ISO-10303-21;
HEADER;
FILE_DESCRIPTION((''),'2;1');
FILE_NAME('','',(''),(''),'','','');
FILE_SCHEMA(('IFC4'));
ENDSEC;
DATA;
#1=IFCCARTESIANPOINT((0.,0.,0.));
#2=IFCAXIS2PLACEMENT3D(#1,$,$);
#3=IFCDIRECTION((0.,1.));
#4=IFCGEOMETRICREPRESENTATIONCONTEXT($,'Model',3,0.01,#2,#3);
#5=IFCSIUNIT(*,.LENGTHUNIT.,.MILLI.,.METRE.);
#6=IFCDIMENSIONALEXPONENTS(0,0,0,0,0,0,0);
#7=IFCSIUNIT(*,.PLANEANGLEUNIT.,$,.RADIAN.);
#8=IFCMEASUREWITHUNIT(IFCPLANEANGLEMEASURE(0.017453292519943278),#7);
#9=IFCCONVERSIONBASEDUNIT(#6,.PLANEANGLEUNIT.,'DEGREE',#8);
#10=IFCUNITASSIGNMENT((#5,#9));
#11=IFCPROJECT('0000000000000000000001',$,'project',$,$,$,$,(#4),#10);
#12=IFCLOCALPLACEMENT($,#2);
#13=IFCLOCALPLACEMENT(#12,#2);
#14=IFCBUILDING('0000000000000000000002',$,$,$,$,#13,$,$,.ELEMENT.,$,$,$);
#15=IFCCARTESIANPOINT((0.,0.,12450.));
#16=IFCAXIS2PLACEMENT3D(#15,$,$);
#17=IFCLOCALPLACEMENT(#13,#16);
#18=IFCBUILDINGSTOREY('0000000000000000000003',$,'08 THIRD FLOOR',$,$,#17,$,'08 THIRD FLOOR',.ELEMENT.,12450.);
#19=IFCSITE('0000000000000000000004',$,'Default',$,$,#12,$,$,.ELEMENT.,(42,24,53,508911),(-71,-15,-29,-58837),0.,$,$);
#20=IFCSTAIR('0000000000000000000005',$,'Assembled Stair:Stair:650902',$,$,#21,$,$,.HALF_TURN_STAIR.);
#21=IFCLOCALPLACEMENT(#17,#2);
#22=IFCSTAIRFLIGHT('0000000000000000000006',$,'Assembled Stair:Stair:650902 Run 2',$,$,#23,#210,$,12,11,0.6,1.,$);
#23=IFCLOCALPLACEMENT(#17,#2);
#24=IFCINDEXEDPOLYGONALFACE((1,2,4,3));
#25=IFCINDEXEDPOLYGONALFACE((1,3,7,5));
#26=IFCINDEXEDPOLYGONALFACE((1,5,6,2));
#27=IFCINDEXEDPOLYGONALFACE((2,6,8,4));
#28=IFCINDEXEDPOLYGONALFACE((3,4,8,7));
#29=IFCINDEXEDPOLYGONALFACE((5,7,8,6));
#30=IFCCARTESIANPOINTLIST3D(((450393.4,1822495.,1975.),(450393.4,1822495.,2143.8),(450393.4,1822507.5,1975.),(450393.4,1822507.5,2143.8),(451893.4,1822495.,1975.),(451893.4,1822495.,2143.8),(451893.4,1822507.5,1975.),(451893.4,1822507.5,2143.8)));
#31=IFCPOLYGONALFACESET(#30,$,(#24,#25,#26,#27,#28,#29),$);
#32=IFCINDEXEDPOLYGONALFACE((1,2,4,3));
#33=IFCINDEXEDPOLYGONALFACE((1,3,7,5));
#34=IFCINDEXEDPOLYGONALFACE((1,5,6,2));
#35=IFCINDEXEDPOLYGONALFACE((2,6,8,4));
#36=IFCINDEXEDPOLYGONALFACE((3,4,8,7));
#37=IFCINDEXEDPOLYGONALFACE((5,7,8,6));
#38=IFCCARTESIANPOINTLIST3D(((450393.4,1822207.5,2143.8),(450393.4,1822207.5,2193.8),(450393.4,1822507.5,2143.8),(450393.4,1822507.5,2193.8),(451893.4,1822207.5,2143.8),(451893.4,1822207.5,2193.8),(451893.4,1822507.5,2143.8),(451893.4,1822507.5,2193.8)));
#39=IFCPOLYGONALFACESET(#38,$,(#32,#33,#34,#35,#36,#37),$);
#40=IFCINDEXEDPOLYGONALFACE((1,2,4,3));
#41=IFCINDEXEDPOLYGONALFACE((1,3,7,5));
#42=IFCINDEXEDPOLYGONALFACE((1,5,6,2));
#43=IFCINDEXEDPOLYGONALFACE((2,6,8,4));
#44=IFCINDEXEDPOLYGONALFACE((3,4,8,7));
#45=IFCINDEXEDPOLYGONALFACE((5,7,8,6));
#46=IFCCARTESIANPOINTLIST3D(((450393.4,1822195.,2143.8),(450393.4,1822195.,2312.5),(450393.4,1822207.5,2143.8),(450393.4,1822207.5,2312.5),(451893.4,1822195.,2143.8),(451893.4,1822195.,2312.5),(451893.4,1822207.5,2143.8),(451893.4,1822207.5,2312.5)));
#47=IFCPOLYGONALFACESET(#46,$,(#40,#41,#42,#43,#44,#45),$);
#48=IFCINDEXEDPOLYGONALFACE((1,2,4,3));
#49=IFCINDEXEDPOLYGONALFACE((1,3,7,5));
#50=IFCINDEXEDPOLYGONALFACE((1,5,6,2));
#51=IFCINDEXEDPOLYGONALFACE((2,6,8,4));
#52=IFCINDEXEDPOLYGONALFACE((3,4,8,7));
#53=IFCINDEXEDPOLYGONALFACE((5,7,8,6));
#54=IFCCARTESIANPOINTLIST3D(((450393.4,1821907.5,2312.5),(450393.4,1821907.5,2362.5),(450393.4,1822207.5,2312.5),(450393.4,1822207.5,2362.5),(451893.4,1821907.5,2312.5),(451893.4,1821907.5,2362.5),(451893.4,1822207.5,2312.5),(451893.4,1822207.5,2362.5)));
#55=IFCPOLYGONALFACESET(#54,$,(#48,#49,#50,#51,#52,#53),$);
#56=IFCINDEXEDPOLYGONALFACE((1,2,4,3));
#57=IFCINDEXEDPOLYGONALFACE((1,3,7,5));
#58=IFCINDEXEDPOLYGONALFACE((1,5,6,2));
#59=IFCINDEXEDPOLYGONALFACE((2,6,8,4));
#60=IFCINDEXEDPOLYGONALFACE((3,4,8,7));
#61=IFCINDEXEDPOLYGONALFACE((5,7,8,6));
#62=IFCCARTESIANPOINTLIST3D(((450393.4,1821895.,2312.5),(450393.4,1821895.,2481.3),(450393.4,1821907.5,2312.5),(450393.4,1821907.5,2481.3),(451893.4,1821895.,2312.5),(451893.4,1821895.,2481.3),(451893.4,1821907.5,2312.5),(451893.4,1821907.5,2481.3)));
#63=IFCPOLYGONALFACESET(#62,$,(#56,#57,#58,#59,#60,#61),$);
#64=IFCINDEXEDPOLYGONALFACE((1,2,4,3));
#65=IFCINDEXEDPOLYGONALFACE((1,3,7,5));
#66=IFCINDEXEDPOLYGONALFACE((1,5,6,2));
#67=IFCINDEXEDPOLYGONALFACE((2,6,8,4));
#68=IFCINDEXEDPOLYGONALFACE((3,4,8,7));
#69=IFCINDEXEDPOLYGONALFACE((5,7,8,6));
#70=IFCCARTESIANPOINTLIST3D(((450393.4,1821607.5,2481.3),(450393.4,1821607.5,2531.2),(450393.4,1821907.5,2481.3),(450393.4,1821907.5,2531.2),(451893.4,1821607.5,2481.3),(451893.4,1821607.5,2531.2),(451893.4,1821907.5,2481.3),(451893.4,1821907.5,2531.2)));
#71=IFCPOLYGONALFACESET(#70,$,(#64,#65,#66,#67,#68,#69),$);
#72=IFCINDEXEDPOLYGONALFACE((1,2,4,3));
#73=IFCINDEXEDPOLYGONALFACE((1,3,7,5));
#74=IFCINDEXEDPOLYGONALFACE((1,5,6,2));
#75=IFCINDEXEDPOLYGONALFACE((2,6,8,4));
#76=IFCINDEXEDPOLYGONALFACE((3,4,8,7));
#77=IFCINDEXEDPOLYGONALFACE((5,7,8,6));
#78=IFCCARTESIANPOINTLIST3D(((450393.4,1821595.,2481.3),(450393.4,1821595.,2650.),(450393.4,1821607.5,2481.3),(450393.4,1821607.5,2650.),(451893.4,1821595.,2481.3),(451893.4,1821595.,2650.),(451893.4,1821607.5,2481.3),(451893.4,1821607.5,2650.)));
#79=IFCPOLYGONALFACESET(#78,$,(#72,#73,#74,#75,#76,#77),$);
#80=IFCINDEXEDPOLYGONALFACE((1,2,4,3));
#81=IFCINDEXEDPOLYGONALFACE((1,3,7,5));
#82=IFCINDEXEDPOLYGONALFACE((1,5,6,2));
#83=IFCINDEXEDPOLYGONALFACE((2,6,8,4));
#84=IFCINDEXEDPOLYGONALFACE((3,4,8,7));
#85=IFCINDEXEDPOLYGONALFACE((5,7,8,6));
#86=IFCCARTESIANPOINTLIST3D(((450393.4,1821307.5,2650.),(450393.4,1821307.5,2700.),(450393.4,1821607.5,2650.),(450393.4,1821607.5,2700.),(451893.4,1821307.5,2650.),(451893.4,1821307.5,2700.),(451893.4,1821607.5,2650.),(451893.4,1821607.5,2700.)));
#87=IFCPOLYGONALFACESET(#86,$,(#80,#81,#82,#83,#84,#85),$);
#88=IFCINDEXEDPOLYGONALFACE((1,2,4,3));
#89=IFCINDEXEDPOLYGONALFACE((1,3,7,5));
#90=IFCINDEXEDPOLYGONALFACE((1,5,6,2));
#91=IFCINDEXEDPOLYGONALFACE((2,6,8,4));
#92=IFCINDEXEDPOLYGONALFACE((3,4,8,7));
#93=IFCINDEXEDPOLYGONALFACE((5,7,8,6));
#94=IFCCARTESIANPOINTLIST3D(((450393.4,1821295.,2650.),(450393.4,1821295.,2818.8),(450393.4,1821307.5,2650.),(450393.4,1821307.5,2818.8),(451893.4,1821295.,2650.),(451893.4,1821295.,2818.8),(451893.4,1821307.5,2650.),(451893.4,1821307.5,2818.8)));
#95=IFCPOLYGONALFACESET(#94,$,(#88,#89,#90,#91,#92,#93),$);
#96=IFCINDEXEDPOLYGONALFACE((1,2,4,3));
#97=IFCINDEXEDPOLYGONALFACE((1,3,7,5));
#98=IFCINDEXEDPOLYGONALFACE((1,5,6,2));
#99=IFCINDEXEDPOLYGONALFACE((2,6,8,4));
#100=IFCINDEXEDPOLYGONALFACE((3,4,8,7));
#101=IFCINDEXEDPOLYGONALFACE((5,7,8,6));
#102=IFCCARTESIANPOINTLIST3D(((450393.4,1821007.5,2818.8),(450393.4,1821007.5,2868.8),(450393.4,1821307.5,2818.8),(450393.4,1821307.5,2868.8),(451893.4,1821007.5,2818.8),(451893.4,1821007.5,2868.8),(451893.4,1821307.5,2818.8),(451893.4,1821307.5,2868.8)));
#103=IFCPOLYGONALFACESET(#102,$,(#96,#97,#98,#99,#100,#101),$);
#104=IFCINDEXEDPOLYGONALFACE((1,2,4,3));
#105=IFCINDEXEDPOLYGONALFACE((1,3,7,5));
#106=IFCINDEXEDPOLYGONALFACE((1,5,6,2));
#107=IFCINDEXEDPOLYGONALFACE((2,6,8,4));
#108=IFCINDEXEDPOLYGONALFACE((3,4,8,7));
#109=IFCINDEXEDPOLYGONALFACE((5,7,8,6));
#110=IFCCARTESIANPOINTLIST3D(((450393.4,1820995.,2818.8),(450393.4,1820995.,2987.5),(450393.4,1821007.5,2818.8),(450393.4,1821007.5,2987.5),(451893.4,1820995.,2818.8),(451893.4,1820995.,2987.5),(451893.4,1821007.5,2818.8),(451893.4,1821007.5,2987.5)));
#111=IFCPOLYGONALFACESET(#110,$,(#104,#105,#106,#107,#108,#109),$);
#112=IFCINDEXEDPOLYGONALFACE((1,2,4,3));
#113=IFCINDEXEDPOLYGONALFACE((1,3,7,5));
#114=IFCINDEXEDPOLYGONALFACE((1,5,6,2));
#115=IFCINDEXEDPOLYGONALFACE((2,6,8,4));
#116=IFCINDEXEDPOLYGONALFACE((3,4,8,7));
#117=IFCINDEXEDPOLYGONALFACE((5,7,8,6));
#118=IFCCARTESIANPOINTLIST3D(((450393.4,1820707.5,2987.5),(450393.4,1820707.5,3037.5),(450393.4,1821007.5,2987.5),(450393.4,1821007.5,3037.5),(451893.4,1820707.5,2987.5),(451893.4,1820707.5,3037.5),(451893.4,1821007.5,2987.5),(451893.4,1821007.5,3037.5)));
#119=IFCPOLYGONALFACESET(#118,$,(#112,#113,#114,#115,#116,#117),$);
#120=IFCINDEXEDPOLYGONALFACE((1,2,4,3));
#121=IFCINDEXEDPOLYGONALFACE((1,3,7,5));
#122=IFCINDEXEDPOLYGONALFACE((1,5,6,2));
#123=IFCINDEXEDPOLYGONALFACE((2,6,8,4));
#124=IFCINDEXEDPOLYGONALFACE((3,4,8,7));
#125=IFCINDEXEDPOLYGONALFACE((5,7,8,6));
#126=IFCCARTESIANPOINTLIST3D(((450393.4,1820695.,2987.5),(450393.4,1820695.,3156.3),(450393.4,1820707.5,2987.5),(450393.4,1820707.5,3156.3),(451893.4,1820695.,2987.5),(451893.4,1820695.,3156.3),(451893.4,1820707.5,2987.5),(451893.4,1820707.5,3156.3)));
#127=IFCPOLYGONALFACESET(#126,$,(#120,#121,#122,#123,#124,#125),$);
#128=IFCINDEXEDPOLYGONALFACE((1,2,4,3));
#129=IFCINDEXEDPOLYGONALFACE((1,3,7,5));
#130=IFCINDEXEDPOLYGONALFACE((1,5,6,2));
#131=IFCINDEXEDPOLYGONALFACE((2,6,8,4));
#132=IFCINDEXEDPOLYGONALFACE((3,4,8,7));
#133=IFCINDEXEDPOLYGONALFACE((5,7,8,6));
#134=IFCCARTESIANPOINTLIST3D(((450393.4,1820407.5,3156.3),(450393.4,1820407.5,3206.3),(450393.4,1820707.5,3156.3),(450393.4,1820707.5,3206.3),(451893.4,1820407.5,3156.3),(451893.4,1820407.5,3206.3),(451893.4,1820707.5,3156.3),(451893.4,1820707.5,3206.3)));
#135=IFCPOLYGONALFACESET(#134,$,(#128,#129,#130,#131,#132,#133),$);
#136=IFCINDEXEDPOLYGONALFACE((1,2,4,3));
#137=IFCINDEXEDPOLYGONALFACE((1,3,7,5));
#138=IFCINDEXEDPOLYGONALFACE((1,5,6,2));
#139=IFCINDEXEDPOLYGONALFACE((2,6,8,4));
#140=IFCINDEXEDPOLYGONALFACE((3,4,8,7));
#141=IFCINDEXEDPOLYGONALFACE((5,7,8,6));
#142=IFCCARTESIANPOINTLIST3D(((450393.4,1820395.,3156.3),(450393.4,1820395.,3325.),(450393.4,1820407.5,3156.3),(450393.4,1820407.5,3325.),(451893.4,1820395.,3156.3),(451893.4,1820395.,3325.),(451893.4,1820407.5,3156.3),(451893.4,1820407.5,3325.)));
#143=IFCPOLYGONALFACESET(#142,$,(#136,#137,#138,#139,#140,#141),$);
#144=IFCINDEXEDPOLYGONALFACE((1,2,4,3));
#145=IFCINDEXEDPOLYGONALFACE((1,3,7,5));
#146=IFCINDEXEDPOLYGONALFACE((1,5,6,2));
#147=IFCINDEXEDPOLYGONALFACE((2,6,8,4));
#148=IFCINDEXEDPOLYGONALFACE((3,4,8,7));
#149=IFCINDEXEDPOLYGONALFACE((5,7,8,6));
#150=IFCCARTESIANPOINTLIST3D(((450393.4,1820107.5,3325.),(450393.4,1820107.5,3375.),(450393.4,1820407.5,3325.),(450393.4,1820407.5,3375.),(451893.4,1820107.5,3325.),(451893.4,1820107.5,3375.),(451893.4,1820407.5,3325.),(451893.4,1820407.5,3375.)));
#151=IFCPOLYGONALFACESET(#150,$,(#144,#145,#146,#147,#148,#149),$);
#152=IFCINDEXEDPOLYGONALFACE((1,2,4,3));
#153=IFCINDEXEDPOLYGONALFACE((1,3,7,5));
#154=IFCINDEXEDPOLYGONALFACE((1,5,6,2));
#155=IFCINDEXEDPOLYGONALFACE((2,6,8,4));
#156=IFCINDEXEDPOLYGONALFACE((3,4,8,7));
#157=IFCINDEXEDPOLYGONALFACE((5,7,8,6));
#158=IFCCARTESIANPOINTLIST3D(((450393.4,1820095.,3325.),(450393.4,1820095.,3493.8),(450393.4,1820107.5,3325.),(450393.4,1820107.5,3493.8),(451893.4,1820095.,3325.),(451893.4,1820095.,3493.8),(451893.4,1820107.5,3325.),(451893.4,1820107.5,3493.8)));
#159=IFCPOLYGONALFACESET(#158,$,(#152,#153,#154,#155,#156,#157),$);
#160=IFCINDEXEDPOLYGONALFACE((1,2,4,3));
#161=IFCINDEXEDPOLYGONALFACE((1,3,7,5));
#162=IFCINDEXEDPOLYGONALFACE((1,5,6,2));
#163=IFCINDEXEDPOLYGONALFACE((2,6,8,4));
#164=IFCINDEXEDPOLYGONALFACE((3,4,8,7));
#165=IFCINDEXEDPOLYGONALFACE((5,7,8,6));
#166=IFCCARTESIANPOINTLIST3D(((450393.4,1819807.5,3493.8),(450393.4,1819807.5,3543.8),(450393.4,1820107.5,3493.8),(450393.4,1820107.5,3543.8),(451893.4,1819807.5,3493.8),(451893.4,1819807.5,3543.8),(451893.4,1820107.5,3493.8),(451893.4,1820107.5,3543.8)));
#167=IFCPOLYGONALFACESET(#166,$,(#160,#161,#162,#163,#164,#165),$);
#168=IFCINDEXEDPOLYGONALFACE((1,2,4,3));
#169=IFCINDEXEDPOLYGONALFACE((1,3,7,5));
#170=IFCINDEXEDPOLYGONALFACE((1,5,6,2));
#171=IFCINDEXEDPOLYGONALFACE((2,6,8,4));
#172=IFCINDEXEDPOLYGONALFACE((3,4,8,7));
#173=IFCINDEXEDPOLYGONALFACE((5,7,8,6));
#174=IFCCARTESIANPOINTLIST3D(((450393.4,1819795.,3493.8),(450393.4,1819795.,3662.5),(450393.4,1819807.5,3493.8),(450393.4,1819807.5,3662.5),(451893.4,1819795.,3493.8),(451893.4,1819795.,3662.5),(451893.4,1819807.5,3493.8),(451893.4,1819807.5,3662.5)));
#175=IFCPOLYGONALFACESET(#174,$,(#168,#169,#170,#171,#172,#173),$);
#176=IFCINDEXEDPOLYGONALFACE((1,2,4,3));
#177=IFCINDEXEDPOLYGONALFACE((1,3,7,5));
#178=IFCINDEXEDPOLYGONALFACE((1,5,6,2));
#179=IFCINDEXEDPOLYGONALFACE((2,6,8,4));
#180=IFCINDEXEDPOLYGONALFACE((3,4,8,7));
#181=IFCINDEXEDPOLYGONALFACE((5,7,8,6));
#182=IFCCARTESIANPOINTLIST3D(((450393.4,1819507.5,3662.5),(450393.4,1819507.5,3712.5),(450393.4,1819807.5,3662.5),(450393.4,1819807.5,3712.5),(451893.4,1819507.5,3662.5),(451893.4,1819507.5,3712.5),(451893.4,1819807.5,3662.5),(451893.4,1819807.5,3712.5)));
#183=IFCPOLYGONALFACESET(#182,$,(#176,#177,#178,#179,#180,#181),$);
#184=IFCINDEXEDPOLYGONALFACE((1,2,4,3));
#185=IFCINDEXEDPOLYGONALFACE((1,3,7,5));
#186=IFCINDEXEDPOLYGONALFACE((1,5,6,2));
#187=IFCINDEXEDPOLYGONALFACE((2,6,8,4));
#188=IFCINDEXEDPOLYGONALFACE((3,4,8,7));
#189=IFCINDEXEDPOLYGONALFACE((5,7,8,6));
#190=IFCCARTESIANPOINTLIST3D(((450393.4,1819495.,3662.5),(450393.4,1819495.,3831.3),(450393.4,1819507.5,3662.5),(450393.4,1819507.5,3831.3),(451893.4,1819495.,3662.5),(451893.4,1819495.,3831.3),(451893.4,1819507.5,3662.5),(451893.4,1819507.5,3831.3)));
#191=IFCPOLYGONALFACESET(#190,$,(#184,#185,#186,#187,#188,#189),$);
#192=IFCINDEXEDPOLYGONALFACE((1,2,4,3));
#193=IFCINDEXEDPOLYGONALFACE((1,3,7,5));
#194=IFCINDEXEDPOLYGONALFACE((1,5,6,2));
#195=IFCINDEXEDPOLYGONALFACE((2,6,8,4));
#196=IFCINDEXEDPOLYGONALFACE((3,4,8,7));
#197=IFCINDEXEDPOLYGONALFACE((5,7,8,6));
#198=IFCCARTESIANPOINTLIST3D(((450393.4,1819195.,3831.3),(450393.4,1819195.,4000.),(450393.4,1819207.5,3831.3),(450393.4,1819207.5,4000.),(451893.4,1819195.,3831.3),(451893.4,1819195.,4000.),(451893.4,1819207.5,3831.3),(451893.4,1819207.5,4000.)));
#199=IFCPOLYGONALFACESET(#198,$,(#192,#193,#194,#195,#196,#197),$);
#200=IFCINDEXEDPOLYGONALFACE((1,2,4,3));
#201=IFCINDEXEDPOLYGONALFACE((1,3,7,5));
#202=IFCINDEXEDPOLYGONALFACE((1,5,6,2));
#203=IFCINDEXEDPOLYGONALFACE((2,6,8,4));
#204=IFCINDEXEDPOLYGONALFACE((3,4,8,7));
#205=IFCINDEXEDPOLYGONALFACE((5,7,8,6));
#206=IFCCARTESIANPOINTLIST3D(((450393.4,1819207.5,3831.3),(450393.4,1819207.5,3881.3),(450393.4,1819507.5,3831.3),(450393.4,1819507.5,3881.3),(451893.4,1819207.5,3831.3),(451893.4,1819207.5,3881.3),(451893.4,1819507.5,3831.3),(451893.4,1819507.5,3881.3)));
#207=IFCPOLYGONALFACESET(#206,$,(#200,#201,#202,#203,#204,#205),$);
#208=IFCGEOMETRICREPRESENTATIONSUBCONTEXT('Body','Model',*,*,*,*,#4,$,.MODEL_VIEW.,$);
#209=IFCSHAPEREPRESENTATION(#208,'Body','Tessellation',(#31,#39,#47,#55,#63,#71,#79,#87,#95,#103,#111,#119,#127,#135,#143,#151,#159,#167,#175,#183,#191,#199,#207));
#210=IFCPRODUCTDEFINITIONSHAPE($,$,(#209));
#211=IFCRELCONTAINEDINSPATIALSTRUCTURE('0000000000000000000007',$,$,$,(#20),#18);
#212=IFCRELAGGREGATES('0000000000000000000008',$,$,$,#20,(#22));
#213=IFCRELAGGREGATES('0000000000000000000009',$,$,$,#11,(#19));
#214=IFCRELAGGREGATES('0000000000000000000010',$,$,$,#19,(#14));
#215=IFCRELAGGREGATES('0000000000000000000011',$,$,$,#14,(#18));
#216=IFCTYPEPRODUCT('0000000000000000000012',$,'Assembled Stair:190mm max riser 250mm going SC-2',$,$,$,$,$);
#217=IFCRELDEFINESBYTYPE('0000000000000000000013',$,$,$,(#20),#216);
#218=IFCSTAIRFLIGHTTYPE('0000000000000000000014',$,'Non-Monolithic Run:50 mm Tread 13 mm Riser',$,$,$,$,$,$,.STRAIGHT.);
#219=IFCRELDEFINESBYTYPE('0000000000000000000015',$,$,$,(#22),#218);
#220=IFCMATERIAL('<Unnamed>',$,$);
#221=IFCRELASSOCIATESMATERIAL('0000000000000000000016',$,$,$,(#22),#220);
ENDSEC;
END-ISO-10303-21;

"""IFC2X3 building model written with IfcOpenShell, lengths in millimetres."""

from ifc_helpers import new_model, entity, si_unit, converted_unit, direction, frame, frame_2d, origin, origin_2d_with_axis, place, context, subcontext, project, spatial, rectangle, extrude, material, type_object, element, aggregate, save


model = new_model("IFC2X3")

# Units and contexts
model_context = context("Model", 3, precision=0.01, world=origin(), true_north=direction((0.0, 1.0)))
body_context = subcontext(model_context, "Body", "Model", "MODEL_VIEW")
ifc_project = project(units=[si_unit("LENGTHUNIT", "METRE", prefix="MILLI"), converted_unit("PLANEANGLEUNIT", "DEGREE", entity("IfcPlaneAngleMeasure", 0.017453292519943278), si_unit("PLANEANGLEUNIT", "RADIAN"), dimensions=[0, 0, 0, 0, 0, 0, 0])], contexts=[model_context])

# Site, building, storey
site_placement = place(None, origin())
site = spatial("IfcSite", under=ifc_project, at=site_placement, Name="Default", CompositionType="ELEMENT", RefLatitude=(42, 24, 53, 508911), RefLongitude=(-71, -15, -29, -58837), RefElevation=0.0)
building_placement = place(site_placement, origin())
building = spatial("IfcBuilding", under=site, at=building_placement, CompositionType="ELEMENT")
storey_placement = place(building_placement, frame((0.0, 0.0, 12450.0)))
storey = spatial("IfcBuildingStorey", under=building, at=storey_placement, Name="08 THIRD FLOOR", LongName="08 THIRD FLOOR", CompositionType="ELEMENT", Elevation=12450.0)

# Stair
ifc_material_1 = material(Name="<Unnamed>")
type_product_1 = type_object("IfcTypeProduct", Name="Assembled Stair:190mm max riser 250mm going SC-2")
stair_1_placement = place(storey_placement, origin())
stair_1 = element("IfcStair", 1, at=stair_1_placement, inside=storey, type_object=type_product_1, Name="Assembled Stair:Stair:650902", ShapeType="HALF_TURN_STAIR")

# Stair flight
stair_flight_type = type_object("IfcStairFlightType", Name="Non-Monolithic Run:50 mm Tread 13 mm Riser", PredefinedType="STRAIGHT")
stair_flight_1_placement = place(stair_1_placement, origin())
stair_flight_1 = element("IfcStairFlight", 2, at=stair_flight_1_placement, type_object=stair_flight_type, material=ifc_material_1, Name="Assembled Stair:Stair:650902 Run 2", NumberOfRiser=12, NumberOfTreads=11, RiserHeight=0.6, TreadLength=1.0, context=body_context, shape_type="SweptSolid", body=[
    extrude(rectangle(XDim=1500.0, YDim=12.5, at=origin_2d_with_axis()), frame((451143.4, 1822501.3, 1975.0)), (0.0, 0.0, 1.0), 168.8),
    extrude(rectangle(XDim=300.0, YDim=1500.0, at=frame_2d((0.0, 0.0), x_axis=(1.0, 0.0))), frame((451143.4, 1822357.5, 2143.8), z_axis=(0.0, 0.0, 1.0), x_axis=(0.0, 1.0, 0.0)), (0.0, 0.0, 1.0), 50.0),
    extrude(rectangle(XDim=1500.0, YDim=12.5, at=origin_2d_with_axis()), frame((451143.4, 1822201.3, 2143.8)), (0.0, 0.0, 1.0), 168.8),
    extrude(rectangle(XDim=300.0, YDim=1500.0, at=origin_2d_with_axis()), frame((451143.4, 1822057.5, 2312.5), z_axis=(0.0, 0.0, 1.0), x_axis=(0.0, 1.0, 0.0)), (0.0, 0.0, 1.0), 50.0),
    extrude(rectangle(XDim=1500.0, YDim=12.5, at=origin_2d_with_axis()), frame((451143.4, 1821901.3, 2312.5)), (0.0, 0.0, 1.0), 168.8),
    extrude(rectangle(XDim=300.0, YDim=1500.0, at=origin_2d_with_axis()), frame((451143.4, 1821757.5, 2481.3), z_axis=(0.0, 0.0, 1.0), x_axis=(0.0, 1.0, 0.0)), (0.0, 0.0, 1.0), 50.0),
    extrude(rectangle(XDim=1500.0, YDim=12.5, at=origin_2d_with_axis()), frame((451143.4, 1821601.3, 2481.3)), (0.0, 0.0, 1.0), 168.8),
    extrude(rectangle(XDim=300.0, YDim=1500.0, at=origin_2d_with_axis()), frame((451143.4, 1821457.5, 2650.0), z_axis=(0.0, 0.0, 1.0), x_axis=(0.0, 1.0, 0.0)), (0.0, 0.0, 1.0), 50.0),
    extrude(rectangle(XDim=1500.0, YDim=12.5, at=origin_2d_with_axis()), frame((451143.4, 1821301.3, 2650.0)), (0.0, 0.0, 1.0), 168.8),
    extrude(rectangle(XDim=300.0, YDim=1500.0, at=origin_2d_with_axis()), frame((451143.4, 1821157.5, 2818.8), z_axis=(0.0, 0.0, 1.0), x_axis=(0.0, 1.0, 0.0)), (0.0, 0.0, 1.0), 50.0),
    extrude(rectangle(XDim=1500.0, YDim=12.5, at=origin_2d_with_axis()), frame((451143.4, 1821001.3, 2818.8)), (0.0, 0.0, 1.0), 168.8),
    extrude(rectangle(XDim=300.0, YDim=1500.0, at=origin_2d_with_axis()), frame((451143.4, 1820857.5, 2987.5), z_axis=(0.0, 0.0, 1.0), x_axis=(0.0, 1.0, 0.0)), (0.0, 0.0, 1.0), 50.0),
    extrude(rectangle(XDim=1500.0, YDim=12.5, at=origin_2d_with_axis()), frame((451143.4, 1820701.3, 2987.5)), (0.0, 0.0, 1.0), 168.8),
    extrude(rectangle(XDim=300.0, YDim=1500.0, at=origin_2d_with_axis()), frame((451143.4, 1820557.5, 3156.3), z_axis=(0.0, 0.0, 1.0), x_axis=(0.0, 1.0, 0.0)), (0.0, 0.0, 1.0), 50.0),
    extrude(rectangle(XDim=1500.0, YDim=12.5, at=origin_2d_with_axis()), frame((451143.4, 1820401.3, 3156.3)), (0.0, 0.0, 1.0), 168.8),
    extrude(rectangle(XDim=300.0, YDim=1500.0, at=origin_2d_with_axis()), frame((451143.4, 1820257.5, 3325.0), z_axis=(0.0, 0.0, 1.0), x_axis=(0.0, 1.0, 0.0)), (0.0, 0.0, 1.0), 50.0),
    extrude(rectangle(XDim=1500.0, YDim=12.5, at=origin_2d_with_axis()), frame((451143.4, 1820101.3, 3325.0)), (0.0, 0.0, 1.0), 168.8),
    extrude(rectangle(XDim=300.0, YDim=1500.0, at=origin_2d_with_axis()), frame((451143.4, 1819957.5, 3493.8), z_axis=(0.0, 0.0, 1.0), x_axis=(0.0, 1.0, 0.0)), (0.0, 0.0, 1.0), 50.0),
    extrude(rectangle(XDim=1500.0, YDim=12.5, at=origin_2d_with_axis()), frame((451143.4, 1819801.3, 3493.8)), (0.0, 0.0, 1.0), 168.8),
    extrude(rectangle(XDim=300.0, YDim=1500.0, at=origin_2d_with_axis()), frame((451143.4, 1819657.5, 3662.5), z_axis=(0.0, 0.0, 1.0), x_axis=(0.0, 1.0, 0.0)), (0.0, 0.0, 1.0), 50.0),
    extrude(rectangle(XDim=1500.0, YDim=12.5, at=origin_2d_with_axis()), frame((451143.4, 1819501.3, 3662.5)), (0.0, 0.0, 1.0), 168.8),
    extrude(rectangle(XDim=1500.0, YDim=12.5, at=origin_2d_with_axis()), frame((451143.4, 1819201.3, 3831.3)), (0.0, 0.0, 1.0), 168.7),
    extrude(rectangle(XDim=300.0, YDim=1500.0, at=origin_2d_with_axis()), frame((451143.4, 1819357.5, 3831.3), z_axis=(0.0, 0.0, 1.0), x_axis=(0.0, 1.0, 0.0)), (0.0, 0.0, 1.0), 50.0),
])

aggregate(stair_1, [stair_flight_1])

save(model, "model.ifc")
